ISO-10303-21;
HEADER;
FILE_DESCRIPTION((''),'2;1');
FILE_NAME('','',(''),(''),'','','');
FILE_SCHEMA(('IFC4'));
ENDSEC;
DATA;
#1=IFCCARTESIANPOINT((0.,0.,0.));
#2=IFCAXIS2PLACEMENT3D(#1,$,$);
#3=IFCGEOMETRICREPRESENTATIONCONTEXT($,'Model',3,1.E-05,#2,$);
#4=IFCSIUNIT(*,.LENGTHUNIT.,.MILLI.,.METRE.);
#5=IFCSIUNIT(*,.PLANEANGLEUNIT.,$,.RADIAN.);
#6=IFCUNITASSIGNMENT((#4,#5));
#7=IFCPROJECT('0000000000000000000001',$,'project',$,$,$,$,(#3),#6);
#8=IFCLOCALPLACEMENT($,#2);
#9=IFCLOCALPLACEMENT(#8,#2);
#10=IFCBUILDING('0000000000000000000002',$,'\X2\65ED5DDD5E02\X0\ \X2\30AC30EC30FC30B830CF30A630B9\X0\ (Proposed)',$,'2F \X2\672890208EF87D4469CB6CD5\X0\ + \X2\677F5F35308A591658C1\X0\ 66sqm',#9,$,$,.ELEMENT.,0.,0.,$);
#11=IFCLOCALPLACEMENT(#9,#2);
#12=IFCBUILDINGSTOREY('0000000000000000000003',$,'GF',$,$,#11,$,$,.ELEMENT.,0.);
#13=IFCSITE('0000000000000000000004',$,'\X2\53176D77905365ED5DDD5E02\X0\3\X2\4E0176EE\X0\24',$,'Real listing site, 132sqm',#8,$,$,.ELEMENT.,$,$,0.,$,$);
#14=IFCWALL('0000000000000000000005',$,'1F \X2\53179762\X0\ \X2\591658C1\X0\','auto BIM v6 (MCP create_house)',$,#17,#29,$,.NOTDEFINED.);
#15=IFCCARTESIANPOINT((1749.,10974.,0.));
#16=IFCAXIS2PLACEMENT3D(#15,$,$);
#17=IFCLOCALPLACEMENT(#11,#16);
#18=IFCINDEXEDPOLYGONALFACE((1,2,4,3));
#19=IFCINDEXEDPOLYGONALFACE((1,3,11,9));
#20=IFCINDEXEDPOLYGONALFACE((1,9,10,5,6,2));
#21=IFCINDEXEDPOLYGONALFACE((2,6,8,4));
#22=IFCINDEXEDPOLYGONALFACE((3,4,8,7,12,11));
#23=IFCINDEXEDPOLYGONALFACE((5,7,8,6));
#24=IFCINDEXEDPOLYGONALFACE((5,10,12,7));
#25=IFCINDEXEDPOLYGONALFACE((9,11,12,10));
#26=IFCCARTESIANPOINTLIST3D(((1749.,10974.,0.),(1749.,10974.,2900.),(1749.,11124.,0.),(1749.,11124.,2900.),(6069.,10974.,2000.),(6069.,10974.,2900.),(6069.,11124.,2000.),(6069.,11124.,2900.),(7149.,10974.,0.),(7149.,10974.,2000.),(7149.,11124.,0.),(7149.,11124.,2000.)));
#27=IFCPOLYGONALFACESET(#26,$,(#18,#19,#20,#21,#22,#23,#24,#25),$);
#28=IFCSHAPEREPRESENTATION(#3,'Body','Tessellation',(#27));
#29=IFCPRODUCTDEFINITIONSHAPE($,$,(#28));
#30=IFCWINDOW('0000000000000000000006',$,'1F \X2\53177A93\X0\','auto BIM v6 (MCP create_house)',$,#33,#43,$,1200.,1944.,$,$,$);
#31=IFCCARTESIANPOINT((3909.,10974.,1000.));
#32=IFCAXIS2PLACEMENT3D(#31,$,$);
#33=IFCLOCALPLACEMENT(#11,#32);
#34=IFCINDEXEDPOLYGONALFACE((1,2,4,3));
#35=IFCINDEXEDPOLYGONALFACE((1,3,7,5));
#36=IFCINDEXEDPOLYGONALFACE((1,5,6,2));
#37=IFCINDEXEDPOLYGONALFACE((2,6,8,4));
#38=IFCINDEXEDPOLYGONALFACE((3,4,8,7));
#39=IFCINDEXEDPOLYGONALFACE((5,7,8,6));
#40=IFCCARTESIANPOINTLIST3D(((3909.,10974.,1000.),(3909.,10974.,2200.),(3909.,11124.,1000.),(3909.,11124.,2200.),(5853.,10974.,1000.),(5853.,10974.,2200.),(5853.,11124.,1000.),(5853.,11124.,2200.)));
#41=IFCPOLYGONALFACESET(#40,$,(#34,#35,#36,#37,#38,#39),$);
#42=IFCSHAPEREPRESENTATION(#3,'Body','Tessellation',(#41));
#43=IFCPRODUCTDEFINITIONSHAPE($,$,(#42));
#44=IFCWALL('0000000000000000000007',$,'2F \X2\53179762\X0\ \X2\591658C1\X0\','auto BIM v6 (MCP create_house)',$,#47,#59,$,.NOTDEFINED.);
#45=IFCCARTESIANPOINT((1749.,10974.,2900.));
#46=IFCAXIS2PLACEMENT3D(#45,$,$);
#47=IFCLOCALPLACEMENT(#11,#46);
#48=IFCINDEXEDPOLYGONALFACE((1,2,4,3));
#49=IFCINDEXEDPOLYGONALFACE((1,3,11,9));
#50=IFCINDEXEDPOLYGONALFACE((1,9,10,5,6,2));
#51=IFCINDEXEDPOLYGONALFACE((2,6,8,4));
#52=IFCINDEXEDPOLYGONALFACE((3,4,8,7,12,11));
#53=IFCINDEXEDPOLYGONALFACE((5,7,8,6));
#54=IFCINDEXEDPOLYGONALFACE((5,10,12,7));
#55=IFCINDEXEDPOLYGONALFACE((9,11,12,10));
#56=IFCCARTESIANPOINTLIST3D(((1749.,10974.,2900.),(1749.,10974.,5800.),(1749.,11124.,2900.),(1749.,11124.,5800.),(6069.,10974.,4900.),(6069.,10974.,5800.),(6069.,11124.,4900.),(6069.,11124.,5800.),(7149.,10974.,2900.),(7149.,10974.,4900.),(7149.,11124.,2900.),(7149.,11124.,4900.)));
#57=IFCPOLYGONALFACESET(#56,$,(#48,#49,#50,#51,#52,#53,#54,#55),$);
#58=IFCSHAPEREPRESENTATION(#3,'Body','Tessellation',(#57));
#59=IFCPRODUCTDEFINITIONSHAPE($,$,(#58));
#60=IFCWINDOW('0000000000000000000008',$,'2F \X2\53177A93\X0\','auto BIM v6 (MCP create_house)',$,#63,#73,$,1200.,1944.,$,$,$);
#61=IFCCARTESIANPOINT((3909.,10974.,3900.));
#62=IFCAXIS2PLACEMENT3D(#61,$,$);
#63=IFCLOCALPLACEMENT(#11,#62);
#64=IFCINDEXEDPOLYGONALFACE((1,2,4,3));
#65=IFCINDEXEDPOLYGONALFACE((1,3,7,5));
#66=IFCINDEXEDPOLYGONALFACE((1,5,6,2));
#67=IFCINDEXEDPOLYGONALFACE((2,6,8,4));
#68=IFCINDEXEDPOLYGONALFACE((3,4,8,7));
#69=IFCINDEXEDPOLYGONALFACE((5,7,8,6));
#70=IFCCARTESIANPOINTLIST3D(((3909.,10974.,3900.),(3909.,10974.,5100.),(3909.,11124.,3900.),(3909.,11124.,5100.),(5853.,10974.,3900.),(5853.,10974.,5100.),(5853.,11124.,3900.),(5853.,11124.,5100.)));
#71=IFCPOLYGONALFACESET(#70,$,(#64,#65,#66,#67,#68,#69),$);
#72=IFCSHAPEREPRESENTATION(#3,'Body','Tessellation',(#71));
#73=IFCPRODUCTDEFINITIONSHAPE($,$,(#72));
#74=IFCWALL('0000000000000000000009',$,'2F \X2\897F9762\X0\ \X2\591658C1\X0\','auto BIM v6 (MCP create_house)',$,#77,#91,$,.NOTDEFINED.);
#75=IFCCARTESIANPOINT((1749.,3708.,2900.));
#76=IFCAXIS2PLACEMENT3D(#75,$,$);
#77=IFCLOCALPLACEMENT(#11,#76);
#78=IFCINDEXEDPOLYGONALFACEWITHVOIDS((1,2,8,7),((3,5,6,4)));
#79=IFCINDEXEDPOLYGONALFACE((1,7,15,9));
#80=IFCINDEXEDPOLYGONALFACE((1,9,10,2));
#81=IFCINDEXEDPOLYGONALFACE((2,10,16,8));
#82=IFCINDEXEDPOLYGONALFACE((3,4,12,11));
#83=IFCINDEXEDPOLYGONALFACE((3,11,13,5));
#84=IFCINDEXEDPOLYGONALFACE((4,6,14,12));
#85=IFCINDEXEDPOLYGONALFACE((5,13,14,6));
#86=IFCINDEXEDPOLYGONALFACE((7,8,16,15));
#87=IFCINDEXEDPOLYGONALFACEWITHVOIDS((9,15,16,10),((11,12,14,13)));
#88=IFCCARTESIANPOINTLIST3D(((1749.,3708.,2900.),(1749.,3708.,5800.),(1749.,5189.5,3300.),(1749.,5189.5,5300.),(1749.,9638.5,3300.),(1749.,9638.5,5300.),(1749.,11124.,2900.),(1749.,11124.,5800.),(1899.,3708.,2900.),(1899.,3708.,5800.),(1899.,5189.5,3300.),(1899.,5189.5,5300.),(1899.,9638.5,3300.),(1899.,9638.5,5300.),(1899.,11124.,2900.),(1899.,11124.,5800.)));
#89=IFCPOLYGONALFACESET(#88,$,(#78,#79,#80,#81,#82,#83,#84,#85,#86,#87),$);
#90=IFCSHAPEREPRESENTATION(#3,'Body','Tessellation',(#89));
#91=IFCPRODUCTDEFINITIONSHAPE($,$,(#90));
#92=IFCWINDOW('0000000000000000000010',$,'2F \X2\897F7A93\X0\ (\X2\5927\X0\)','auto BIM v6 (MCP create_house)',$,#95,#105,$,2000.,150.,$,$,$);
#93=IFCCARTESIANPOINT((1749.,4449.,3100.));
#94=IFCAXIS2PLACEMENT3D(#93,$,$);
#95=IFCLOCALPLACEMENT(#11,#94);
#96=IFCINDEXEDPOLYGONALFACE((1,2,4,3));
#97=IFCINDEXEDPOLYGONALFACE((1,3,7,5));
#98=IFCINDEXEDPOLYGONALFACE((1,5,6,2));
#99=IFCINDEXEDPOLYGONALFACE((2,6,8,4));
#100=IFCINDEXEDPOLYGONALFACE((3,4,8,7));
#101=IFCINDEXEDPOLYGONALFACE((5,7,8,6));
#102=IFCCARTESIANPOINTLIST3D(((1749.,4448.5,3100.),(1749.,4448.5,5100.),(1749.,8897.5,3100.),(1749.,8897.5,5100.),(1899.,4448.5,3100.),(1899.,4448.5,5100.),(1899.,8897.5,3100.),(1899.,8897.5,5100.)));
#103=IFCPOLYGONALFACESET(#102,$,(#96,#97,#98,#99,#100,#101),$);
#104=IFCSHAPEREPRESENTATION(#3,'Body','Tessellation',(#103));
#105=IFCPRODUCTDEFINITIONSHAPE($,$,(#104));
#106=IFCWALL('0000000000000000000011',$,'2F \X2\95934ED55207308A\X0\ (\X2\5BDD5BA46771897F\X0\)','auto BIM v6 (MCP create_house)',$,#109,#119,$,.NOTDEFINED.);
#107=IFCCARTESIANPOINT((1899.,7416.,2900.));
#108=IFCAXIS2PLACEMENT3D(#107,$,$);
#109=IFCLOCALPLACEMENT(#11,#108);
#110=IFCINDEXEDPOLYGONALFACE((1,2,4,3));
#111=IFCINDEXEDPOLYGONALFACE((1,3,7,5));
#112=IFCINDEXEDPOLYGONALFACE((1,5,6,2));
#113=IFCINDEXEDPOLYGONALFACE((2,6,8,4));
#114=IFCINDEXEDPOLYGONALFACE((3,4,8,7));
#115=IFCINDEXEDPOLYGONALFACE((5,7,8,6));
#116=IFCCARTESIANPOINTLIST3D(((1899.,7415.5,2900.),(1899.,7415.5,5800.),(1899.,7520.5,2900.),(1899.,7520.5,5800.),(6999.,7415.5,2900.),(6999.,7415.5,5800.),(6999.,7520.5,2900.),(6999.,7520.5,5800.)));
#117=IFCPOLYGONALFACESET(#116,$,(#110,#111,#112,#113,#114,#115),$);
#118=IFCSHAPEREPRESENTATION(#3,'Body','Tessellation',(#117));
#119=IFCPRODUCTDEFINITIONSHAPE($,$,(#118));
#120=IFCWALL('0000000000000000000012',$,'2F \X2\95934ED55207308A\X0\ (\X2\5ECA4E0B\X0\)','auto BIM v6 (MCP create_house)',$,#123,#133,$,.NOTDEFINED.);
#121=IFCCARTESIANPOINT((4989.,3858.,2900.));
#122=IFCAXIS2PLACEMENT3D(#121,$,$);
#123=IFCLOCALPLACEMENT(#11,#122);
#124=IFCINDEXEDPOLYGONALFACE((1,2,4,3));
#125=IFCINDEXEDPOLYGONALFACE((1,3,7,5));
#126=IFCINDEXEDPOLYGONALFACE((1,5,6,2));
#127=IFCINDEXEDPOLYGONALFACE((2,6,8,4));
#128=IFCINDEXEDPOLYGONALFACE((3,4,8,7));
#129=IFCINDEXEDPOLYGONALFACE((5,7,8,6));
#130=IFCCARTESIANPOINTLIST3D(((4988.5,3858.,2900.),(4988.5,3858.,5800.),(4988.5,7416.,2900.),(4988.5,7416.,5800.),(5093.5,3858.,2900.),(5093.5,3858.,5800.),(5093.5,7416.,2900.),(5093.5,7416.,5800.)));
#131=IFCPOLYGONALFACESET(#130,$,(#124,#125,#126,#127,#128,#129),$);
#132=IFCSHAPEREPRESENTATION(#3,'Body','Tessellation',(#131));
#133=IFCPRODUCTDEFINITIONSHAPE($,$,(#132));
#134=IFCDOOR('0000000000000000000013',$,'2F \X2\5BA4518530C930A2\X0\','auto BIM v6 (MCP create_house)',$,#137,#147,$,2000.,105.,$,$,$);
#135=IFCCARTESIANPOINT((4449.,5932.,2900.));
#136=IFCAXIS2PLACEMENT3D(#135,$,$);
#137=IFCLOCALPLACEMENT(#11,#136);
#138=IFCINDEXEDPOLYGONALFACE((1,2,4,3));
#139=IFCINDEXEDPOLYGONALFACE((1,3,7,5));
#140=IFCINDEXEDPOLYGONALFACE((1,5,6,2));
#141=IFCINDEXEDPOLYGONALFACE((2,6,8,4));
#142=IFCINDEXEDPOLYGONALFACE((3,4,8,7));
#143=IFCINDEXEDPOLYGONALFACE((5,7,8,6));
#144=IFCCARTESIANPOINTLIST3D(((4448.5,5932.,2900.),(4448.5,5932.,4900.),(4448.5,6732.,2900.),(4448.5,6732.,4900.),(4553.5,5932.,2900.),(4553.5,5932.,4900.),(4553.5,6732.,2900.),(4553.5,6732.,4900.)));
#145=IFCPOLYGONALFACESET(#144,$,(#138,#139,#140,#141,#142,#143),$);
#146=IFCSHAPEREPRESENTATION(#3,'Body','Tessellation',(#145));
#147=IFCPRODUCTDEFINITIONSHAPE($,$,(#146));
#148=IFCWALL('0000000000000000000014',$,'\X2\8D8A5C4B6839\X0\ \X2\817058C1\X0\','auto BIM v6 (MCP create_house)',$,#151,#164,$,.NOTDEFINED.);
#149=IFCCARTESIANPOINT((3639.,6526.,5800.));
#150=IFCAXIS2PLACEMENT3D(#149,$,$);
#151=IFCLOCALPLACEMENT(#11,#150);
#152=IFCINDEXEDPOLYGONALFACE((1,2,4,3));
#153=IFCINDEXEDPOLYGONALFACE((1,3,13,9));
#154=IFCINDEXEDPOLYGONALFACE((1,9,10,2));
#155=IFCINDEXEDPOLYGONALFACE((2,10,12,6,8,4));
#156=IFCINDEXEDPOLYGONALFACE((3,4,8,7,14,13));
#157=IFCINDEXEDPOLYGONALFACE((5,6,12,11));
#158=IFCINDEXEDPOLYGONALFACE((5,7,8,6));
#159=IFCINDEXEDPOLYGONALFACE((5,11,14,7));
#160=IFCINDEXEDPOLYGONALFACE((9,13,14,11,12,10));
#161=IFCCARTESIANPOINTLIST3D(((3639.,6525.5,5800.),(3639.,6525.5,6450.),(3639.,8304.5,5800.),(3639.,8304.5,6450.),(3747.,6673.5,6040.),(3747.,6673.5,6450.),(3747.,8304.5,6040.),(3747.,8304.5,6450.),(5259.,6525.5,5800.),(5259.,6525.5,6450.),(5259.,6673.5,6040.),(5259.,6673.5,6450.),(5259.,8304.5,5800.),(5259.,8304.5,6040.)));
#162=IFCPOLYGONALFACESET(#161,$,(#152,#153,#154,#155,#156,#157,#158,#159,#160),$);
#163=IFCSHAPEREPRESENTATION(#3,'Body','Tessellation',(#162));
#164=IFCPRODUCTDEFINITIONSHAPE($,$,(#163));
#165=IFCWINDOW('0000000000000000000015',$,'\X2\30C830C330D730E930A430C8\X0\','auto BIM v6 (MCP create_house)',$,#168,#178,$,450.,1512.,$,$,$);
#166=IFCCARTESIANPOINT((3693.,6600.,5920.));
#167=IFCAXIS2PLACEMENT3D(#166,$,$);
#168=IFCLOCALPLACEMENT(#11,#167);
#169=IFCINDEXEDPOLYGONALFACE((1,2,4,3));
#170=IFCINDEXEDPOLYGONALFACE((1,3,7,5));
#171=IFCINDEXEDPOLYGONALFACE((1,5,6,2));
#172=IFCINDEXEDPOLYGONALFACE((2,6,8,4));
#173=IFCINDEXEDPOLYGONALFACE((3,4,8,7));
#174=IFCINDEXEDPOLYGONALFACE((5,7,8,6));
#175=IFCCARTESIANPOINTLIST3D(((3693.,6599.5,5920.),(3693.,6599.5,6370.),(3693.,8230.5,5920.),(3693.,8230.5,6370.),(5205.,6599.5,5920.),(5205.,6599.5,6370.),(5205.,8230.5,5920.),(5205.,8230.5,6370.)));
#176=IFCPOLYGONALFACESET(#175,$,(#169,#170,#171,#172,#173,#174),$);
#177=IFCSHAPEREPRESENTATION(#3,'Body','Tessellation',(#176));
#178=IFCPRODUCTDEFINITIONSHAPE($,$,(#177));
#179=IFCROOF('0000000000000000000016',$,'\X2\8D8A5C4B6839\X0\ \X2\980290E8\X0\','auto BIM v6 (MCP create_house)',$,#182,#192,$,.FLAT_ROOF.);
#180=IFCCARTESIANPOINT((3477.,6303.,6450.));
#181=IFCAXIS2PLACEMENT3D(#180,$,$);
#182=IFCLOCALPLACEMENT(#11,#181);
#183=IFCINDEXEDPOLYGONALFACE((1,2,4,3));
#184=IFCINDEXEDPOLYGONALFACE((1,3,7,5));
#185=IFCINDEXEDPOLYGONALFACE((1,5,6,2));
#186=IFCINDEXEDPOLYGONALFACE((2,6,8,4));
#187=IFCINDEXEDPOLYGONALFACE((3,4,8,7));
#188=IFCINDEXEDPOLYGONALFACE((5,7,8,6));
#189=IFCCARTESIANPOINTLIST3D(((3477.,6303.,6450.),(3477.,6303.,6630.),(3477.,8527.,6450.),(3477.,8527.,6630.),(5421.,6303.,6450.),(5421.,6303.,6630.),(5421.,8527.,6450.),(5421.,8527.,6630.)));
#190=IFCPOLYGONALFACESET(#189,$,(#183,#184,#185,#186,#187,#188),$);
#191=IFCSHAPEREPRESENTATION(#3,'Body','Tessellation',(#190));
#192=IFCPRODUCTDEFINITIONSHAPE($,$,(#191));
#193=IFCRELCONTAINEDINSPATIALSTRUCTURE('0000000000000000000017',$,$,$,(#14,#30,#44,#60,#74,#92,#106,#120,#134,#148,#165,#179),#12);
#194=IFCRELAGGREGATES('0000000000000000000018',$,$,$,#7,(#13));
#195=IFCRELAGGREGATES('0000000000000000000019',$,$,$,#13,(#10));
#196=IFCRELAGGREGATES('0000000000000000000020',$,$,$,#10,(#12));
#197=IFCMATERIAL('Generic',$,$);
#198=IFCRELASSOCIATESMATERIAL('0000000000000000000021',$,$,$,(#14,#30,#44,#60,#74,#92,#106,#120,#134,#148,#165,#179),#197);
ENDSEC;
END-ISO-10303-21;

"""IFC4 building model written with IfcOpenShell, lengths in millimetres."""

from ifc_helpers import new_model, si_unit, frame, frame_2d, origin, place, context, project, spatial, rectangle, extrude, material, element, fill, save


model = new_model("IFC4")

# Units and contexts
model_context = context("Model", 3, precision=1e-05, world=origin())
ifc_project = project(units=[si_unit("LENGTHUNIT", "METRE", prefix="MILLI"), si_unit("PLANEANGLEUNIT", "RADIAN")], contexts=[model_context])

# Site, building, storey
site_placement = place(None, origin())
site = spatial("IfcSite", under=ifc_project, at=site_placement, Name="北海道旭川市3丁目24", ObjectType="Real listing site, 132sqm", CompositionType="ELEMENT", RefElevation=0.0)
building_placement = place(site_placement, origin())
building = spatial("IfcBuilding", under=site, at=building_placement, Name="旭川市 ガレージハウス (Proposed)", ObjectType="2F 木造軸組構法 + 板張り外壁 66sqm", CompositionType="ELEMENT", ElevationOfRefHeight=0.0, ElevationOfTerrain=0.0)
storey_placement = place(building_placement, origin())
storey = spatial("IfcBuildingStorey", under=building, at=storey_placement, Name="GF", CompositionType="ELEMENT", Elevation=0.0)

# Wall, opening, window
ifc_material = material(Name="Generic")
wall_1_placement = place(storey_placement, frame((1749.0, 10974.0, 0.0)))
wall_1 = element("IfcWall", 1, at=wall_1_placement, inside=storey, material=ifc_material, Name="1F 北面 外壁", Description="auto BIM v6 (MCP create_house)", PredefinedType="NOTDEFINED", context=model_context, shape_type="SweptSolid", body=[
    extrude(rectangle(XDim=5400.0, YDim=150.0, at=frame_2d((2700.0, 75.0))), frame((1749.0, 10974.0, 0.0)), (0.0, 0.0, 1.0), 2900.0),
])
opening_1_placement = place(storey_placement, frame((3909.0, 10974.0, 1000.0)))
opening_1 = element("IfcOpeningElement", 2, at=opening_1_placement, cuts=wall_1, PredefinedType="NOTDEFINED", context=model_context, shape_type="SweptSolid", body=[
    extrude(rectangle(XDim=1944.0, YDim=150.0, at=frame_2d((972.0, 75.0))), frame((3909.0, 10974.0, 1000.0)), (0.0, 0.0, 1.0), 1200.0),
])
window_1_placement = place(storey_placement, frame((3909.0, 10974.0, 1000.0)))
window_1 = element("IfcWindow", 3, at=window_1_placement, inside=storey, material=ifc_material, Name="1F 北窓", Description="auto BIM v6 (MCP create_house)", OverallHeight=1200.0, OverallWidth=1944.0, context=model_context, shape_type="SweptSolid", body=[
    extrude(rectangle(XDim=1944.0, YDim=150.0, at=frame_2d((972.0, 75.0))), frame((3909.0, 10974.0, 1000.0)), (0.0, 0.0, 1.0), 1200.0),
])
fill(opening_1, window_1)

# Walls, openings, windows
wall_2_placement = place(storey_placement, frame((1749.0, 10974.0, 2900.0)))
wall_2 = element("IfcWall", 4, at=wall_2_placement, inside=storey, material=ifc_material, Name="2F 北面 外壁", Description="auto BIM v6 (MCP create_house)", PredefinedType="NOTDEFINED", context=model_context, shape_type="SweptSolid", body=[
    extrude(rectangle(XDim=5400.0, YDim=150.0, at=frame_2d((2700.0, 75.0))), frame((1749.0, 10974.0, 2900.0)), (0.0, 0.0, 1.0), 2900.0),
])
opening_2_placement = place(storey_placement, frame((3909.0, 10974.0, 3900.0)))
opening_2 = element("IfcOpeningElement", 5, at=opening_2_placement, cuts=wall_2, PredefinedType="NOTDEFINED", context=model_context, shape_type="SweptSolid", body=[
    extrude(rectangle(XDim=1944.0, YDim=150.0, at=frame_2d((972.0, 75.0))), frame((3909.0, 10974.0, 3900.0)), (0.0, 0.0, 1.0), 1200.0),
])
window_2_placement = place(storey_placement, frame((3909.0, 10974.0, 3900.0)))
window_2 = element("IfcWindow", 6, at=window_2_placement, inside=storey, material=ifc_material, Name="2F 北窓", Description="auto BIM v6 (MCP create_house)", OverallHeight=1200.0, OverallWidth=1944.0, context=model_context, shape_type="SweptSolid", body=[
    extrude(rectangle(XDim=1944.0, YDim=150.0, at=frame_2d((972.0, 75.0))), frame((3909.0, 10974.0, 3900.0)), (0.0, 0.0, 1.0), 1200.0),
])
fill(opening_2, window_2)
wall_3_placement = place(storey_placement, frame((1749.0, 3708.0, 2900.0)))
wall_3 = element("IfcWall", 7, at=wall_3_placement, inside=storey, material=ifc_material, Name="2F 西面 外壁", Description="auto BIM v6 (MCP create_house)", PredefinedType="NOTDEFINED", context=model_context, shape_type="SweptSolid", body=[
    extrude(rectangle(XDim=150.0, YDim=7416.0, at=frame_2d((75.0, 3708.0))), frame((1749.0, 3708.0, 2900.0)), (0.0, 0.0, 1.0), 2900.0),
])
opening_3_placement = place(storey_placement, frame((1749.0, 4449.0, 3100.0)))
opening_3 = element("IfcOpeningElement", 8, at=opening_3_placement, cuts=wall_3, PredefinedType="NOTDEFINED", context=model_context, shape_type="SweptSolid", body=[
    extrude(rectangle(XDim=150.0, YDim=4449.0, at=frame_2d((75.0, 2224.0))), frame((1749.0, 4449.0, 3100.0)), (0.0, 0.0, 1.0), 2000.0),
])
window_3_placement = place(storey_placement, frame((1749.0, 4449.0, 3100.0)))
window_3 = element("IfcWindow", 9, at=window_3_placement, inside=storey, material=ifc_material, Name="2F 西窓 (大)", Description="auto BIM v6 (MCP create_house)", OverallHeight=2000.0, OverallWidth=150.0, context=model_context, shape_type="SweptSolid", body=[
    extrude(rectangle(XDim=150.0, YDim=4449.0, at=frame_2d((75.0, 2224.0))), frame((1749.0, 4449.0, 3100.0)), (0.0, 0.0, 1.0), 2000.0),
])
fill(opening_3, window_3)

# Walls
wall_4_placement = place(storey_placement, frame((1899.0, 7416.0, 2900.0)))
element("IfcWall", 10, at=wall_4_placement, inside=storey, material=ifc_material, Name="2F 間仕切り (寝室東西)", Description="auto BIM v6 (MCP create_house)", PredefinedType="NOTDEFINED", context=model_context, shape_type="SweptSolid", body=[
    extrude(rectangle(XDim=5100.0, YDim=105.0, at=frame_2d((2550.0, 52.0))), frame((1899.0, 7416.0, 2900.0)), (0.0, 0.0, 1.0), 2900.0),
])
wall_5_placement = place(storey_placement, frame((4989.0, 3858.0, 2900.0)))
element("IfcWall", 11, at=wall_5_placement, inside=storey, material=ifc_material, Name="2F 間仕切り (廊下)", Description="auto BIM v6 (MCP create_house)", PredefinedType="NOTDEFINED", context=model_context, shape_type="SweptSolid", body=[
    extrude(rectangle(XDim=105.0, YDim=3558.0, at=frame_2d((52.0, 1779.0))), frame((4989.0, 3858.0, 2900.0)), (0.0, 0.0, 1.0), 2900.0),
])

# Door
door_placement = place(storey_placement, frame((4449.0, 5932.0, 2900.0)))
element("IfcDoor", 12, at=door_placement, inside=storey, material=ifc_material, Name="2F 室内ドア", Description="auto BIM v6 (MCP create_house)", OverallHeight=2000.0, OverallWidth=105.0, context=model_context, shape_type="SweptSolid", body=[
    extrude(rectangle(XDim=105.0, YDim=800.0, at=frame_2d((52.0, 400.0))), frame((4449.0, 5932.0, 2900.0)), (0.0, 0.0, 1.0), 2000.0),
])

# Wall, opening, window
wall_6_placement = place(storey_placement, frame((3639.0, 6526.0, 5800.0)))
wall_6 = element("IfcWall", 13, at=wall_6_placement, inside=storey, material=ifc_material, Name="越屋根 腰壁", Description="auto BIM v6 (MCP create_house)", PredefinedType="NOTDEFINED", context=model_context, shape_type="SweptSolid", body=[
    extrude(rectangle(XDim=1620.0, YDim=1779.0, at=frame_2d((810.0, 889.0))), frame((3639.0, 6526.0, 5800.0)), (0.0, 0.0, 1.0), 650.0),
])
opening_4_placement = place(storey_placement, frame((3693.0, 6600.0, 5920.0)))
opening_4 = element("IfcOpeningElement", 14, at=opening_4_placement, cuts=wall_6, PredefinedType="NOTDEFINED", context=model_context, shape_type="SweptSolid", body=[
    extrude(rectangle(XDim=1512.0, YDim=1631.0, at=frame_2d((756.0, 815.0))), frame((3693.0, 6600.0, 5920.0)), (0.0, 0.0, 1.0), 450.0),
])
window_4_placement = place(storey_placement, frame((3693.0, 6600.0, 5920.0)))
window_4 = element("IfcWindow", 15, at=window_4_placement, inside=storey, material=ifc_material, Name="トップライト", Description="auto BIM v6 (MCP create_house)", OverallHeight=450.0, OverallWidth=1512.0, context=model_context, shape_type="SweptSolid", body=[
    extrude(rectangle(XDim=1512.0, YDim=1631.0, at=frame_2d((756.0, 815.0))), frame((3693.0, 6600.0, 5920.0)), (0.0, 0.0, 1.0), 450.0),
])
fill(opening_4, window_4)

# Roof
roof_placement = place(storey_placement, frame((3477.0, 6303.0, 6450.0)))
element("IfcRoof", 16, at=roof_placement, inside=storey, material=ifc_material, Name="越屋根 頂部", Description="auto BIM v6 (MCP create_house)", PredefinedType="FLAT_ROOF", context=model_context, shape_type="SweptSolid", body=[
    extrude(rectangle(XDim=1944.0, YDim=2224.0, at=frame_2d((972.0, 1112.0))), frame((3477.0, 6303.0, 6450.0)), (0.0, 0.0, 1.0), 180.0),
])

save(model, "model.ifc")
